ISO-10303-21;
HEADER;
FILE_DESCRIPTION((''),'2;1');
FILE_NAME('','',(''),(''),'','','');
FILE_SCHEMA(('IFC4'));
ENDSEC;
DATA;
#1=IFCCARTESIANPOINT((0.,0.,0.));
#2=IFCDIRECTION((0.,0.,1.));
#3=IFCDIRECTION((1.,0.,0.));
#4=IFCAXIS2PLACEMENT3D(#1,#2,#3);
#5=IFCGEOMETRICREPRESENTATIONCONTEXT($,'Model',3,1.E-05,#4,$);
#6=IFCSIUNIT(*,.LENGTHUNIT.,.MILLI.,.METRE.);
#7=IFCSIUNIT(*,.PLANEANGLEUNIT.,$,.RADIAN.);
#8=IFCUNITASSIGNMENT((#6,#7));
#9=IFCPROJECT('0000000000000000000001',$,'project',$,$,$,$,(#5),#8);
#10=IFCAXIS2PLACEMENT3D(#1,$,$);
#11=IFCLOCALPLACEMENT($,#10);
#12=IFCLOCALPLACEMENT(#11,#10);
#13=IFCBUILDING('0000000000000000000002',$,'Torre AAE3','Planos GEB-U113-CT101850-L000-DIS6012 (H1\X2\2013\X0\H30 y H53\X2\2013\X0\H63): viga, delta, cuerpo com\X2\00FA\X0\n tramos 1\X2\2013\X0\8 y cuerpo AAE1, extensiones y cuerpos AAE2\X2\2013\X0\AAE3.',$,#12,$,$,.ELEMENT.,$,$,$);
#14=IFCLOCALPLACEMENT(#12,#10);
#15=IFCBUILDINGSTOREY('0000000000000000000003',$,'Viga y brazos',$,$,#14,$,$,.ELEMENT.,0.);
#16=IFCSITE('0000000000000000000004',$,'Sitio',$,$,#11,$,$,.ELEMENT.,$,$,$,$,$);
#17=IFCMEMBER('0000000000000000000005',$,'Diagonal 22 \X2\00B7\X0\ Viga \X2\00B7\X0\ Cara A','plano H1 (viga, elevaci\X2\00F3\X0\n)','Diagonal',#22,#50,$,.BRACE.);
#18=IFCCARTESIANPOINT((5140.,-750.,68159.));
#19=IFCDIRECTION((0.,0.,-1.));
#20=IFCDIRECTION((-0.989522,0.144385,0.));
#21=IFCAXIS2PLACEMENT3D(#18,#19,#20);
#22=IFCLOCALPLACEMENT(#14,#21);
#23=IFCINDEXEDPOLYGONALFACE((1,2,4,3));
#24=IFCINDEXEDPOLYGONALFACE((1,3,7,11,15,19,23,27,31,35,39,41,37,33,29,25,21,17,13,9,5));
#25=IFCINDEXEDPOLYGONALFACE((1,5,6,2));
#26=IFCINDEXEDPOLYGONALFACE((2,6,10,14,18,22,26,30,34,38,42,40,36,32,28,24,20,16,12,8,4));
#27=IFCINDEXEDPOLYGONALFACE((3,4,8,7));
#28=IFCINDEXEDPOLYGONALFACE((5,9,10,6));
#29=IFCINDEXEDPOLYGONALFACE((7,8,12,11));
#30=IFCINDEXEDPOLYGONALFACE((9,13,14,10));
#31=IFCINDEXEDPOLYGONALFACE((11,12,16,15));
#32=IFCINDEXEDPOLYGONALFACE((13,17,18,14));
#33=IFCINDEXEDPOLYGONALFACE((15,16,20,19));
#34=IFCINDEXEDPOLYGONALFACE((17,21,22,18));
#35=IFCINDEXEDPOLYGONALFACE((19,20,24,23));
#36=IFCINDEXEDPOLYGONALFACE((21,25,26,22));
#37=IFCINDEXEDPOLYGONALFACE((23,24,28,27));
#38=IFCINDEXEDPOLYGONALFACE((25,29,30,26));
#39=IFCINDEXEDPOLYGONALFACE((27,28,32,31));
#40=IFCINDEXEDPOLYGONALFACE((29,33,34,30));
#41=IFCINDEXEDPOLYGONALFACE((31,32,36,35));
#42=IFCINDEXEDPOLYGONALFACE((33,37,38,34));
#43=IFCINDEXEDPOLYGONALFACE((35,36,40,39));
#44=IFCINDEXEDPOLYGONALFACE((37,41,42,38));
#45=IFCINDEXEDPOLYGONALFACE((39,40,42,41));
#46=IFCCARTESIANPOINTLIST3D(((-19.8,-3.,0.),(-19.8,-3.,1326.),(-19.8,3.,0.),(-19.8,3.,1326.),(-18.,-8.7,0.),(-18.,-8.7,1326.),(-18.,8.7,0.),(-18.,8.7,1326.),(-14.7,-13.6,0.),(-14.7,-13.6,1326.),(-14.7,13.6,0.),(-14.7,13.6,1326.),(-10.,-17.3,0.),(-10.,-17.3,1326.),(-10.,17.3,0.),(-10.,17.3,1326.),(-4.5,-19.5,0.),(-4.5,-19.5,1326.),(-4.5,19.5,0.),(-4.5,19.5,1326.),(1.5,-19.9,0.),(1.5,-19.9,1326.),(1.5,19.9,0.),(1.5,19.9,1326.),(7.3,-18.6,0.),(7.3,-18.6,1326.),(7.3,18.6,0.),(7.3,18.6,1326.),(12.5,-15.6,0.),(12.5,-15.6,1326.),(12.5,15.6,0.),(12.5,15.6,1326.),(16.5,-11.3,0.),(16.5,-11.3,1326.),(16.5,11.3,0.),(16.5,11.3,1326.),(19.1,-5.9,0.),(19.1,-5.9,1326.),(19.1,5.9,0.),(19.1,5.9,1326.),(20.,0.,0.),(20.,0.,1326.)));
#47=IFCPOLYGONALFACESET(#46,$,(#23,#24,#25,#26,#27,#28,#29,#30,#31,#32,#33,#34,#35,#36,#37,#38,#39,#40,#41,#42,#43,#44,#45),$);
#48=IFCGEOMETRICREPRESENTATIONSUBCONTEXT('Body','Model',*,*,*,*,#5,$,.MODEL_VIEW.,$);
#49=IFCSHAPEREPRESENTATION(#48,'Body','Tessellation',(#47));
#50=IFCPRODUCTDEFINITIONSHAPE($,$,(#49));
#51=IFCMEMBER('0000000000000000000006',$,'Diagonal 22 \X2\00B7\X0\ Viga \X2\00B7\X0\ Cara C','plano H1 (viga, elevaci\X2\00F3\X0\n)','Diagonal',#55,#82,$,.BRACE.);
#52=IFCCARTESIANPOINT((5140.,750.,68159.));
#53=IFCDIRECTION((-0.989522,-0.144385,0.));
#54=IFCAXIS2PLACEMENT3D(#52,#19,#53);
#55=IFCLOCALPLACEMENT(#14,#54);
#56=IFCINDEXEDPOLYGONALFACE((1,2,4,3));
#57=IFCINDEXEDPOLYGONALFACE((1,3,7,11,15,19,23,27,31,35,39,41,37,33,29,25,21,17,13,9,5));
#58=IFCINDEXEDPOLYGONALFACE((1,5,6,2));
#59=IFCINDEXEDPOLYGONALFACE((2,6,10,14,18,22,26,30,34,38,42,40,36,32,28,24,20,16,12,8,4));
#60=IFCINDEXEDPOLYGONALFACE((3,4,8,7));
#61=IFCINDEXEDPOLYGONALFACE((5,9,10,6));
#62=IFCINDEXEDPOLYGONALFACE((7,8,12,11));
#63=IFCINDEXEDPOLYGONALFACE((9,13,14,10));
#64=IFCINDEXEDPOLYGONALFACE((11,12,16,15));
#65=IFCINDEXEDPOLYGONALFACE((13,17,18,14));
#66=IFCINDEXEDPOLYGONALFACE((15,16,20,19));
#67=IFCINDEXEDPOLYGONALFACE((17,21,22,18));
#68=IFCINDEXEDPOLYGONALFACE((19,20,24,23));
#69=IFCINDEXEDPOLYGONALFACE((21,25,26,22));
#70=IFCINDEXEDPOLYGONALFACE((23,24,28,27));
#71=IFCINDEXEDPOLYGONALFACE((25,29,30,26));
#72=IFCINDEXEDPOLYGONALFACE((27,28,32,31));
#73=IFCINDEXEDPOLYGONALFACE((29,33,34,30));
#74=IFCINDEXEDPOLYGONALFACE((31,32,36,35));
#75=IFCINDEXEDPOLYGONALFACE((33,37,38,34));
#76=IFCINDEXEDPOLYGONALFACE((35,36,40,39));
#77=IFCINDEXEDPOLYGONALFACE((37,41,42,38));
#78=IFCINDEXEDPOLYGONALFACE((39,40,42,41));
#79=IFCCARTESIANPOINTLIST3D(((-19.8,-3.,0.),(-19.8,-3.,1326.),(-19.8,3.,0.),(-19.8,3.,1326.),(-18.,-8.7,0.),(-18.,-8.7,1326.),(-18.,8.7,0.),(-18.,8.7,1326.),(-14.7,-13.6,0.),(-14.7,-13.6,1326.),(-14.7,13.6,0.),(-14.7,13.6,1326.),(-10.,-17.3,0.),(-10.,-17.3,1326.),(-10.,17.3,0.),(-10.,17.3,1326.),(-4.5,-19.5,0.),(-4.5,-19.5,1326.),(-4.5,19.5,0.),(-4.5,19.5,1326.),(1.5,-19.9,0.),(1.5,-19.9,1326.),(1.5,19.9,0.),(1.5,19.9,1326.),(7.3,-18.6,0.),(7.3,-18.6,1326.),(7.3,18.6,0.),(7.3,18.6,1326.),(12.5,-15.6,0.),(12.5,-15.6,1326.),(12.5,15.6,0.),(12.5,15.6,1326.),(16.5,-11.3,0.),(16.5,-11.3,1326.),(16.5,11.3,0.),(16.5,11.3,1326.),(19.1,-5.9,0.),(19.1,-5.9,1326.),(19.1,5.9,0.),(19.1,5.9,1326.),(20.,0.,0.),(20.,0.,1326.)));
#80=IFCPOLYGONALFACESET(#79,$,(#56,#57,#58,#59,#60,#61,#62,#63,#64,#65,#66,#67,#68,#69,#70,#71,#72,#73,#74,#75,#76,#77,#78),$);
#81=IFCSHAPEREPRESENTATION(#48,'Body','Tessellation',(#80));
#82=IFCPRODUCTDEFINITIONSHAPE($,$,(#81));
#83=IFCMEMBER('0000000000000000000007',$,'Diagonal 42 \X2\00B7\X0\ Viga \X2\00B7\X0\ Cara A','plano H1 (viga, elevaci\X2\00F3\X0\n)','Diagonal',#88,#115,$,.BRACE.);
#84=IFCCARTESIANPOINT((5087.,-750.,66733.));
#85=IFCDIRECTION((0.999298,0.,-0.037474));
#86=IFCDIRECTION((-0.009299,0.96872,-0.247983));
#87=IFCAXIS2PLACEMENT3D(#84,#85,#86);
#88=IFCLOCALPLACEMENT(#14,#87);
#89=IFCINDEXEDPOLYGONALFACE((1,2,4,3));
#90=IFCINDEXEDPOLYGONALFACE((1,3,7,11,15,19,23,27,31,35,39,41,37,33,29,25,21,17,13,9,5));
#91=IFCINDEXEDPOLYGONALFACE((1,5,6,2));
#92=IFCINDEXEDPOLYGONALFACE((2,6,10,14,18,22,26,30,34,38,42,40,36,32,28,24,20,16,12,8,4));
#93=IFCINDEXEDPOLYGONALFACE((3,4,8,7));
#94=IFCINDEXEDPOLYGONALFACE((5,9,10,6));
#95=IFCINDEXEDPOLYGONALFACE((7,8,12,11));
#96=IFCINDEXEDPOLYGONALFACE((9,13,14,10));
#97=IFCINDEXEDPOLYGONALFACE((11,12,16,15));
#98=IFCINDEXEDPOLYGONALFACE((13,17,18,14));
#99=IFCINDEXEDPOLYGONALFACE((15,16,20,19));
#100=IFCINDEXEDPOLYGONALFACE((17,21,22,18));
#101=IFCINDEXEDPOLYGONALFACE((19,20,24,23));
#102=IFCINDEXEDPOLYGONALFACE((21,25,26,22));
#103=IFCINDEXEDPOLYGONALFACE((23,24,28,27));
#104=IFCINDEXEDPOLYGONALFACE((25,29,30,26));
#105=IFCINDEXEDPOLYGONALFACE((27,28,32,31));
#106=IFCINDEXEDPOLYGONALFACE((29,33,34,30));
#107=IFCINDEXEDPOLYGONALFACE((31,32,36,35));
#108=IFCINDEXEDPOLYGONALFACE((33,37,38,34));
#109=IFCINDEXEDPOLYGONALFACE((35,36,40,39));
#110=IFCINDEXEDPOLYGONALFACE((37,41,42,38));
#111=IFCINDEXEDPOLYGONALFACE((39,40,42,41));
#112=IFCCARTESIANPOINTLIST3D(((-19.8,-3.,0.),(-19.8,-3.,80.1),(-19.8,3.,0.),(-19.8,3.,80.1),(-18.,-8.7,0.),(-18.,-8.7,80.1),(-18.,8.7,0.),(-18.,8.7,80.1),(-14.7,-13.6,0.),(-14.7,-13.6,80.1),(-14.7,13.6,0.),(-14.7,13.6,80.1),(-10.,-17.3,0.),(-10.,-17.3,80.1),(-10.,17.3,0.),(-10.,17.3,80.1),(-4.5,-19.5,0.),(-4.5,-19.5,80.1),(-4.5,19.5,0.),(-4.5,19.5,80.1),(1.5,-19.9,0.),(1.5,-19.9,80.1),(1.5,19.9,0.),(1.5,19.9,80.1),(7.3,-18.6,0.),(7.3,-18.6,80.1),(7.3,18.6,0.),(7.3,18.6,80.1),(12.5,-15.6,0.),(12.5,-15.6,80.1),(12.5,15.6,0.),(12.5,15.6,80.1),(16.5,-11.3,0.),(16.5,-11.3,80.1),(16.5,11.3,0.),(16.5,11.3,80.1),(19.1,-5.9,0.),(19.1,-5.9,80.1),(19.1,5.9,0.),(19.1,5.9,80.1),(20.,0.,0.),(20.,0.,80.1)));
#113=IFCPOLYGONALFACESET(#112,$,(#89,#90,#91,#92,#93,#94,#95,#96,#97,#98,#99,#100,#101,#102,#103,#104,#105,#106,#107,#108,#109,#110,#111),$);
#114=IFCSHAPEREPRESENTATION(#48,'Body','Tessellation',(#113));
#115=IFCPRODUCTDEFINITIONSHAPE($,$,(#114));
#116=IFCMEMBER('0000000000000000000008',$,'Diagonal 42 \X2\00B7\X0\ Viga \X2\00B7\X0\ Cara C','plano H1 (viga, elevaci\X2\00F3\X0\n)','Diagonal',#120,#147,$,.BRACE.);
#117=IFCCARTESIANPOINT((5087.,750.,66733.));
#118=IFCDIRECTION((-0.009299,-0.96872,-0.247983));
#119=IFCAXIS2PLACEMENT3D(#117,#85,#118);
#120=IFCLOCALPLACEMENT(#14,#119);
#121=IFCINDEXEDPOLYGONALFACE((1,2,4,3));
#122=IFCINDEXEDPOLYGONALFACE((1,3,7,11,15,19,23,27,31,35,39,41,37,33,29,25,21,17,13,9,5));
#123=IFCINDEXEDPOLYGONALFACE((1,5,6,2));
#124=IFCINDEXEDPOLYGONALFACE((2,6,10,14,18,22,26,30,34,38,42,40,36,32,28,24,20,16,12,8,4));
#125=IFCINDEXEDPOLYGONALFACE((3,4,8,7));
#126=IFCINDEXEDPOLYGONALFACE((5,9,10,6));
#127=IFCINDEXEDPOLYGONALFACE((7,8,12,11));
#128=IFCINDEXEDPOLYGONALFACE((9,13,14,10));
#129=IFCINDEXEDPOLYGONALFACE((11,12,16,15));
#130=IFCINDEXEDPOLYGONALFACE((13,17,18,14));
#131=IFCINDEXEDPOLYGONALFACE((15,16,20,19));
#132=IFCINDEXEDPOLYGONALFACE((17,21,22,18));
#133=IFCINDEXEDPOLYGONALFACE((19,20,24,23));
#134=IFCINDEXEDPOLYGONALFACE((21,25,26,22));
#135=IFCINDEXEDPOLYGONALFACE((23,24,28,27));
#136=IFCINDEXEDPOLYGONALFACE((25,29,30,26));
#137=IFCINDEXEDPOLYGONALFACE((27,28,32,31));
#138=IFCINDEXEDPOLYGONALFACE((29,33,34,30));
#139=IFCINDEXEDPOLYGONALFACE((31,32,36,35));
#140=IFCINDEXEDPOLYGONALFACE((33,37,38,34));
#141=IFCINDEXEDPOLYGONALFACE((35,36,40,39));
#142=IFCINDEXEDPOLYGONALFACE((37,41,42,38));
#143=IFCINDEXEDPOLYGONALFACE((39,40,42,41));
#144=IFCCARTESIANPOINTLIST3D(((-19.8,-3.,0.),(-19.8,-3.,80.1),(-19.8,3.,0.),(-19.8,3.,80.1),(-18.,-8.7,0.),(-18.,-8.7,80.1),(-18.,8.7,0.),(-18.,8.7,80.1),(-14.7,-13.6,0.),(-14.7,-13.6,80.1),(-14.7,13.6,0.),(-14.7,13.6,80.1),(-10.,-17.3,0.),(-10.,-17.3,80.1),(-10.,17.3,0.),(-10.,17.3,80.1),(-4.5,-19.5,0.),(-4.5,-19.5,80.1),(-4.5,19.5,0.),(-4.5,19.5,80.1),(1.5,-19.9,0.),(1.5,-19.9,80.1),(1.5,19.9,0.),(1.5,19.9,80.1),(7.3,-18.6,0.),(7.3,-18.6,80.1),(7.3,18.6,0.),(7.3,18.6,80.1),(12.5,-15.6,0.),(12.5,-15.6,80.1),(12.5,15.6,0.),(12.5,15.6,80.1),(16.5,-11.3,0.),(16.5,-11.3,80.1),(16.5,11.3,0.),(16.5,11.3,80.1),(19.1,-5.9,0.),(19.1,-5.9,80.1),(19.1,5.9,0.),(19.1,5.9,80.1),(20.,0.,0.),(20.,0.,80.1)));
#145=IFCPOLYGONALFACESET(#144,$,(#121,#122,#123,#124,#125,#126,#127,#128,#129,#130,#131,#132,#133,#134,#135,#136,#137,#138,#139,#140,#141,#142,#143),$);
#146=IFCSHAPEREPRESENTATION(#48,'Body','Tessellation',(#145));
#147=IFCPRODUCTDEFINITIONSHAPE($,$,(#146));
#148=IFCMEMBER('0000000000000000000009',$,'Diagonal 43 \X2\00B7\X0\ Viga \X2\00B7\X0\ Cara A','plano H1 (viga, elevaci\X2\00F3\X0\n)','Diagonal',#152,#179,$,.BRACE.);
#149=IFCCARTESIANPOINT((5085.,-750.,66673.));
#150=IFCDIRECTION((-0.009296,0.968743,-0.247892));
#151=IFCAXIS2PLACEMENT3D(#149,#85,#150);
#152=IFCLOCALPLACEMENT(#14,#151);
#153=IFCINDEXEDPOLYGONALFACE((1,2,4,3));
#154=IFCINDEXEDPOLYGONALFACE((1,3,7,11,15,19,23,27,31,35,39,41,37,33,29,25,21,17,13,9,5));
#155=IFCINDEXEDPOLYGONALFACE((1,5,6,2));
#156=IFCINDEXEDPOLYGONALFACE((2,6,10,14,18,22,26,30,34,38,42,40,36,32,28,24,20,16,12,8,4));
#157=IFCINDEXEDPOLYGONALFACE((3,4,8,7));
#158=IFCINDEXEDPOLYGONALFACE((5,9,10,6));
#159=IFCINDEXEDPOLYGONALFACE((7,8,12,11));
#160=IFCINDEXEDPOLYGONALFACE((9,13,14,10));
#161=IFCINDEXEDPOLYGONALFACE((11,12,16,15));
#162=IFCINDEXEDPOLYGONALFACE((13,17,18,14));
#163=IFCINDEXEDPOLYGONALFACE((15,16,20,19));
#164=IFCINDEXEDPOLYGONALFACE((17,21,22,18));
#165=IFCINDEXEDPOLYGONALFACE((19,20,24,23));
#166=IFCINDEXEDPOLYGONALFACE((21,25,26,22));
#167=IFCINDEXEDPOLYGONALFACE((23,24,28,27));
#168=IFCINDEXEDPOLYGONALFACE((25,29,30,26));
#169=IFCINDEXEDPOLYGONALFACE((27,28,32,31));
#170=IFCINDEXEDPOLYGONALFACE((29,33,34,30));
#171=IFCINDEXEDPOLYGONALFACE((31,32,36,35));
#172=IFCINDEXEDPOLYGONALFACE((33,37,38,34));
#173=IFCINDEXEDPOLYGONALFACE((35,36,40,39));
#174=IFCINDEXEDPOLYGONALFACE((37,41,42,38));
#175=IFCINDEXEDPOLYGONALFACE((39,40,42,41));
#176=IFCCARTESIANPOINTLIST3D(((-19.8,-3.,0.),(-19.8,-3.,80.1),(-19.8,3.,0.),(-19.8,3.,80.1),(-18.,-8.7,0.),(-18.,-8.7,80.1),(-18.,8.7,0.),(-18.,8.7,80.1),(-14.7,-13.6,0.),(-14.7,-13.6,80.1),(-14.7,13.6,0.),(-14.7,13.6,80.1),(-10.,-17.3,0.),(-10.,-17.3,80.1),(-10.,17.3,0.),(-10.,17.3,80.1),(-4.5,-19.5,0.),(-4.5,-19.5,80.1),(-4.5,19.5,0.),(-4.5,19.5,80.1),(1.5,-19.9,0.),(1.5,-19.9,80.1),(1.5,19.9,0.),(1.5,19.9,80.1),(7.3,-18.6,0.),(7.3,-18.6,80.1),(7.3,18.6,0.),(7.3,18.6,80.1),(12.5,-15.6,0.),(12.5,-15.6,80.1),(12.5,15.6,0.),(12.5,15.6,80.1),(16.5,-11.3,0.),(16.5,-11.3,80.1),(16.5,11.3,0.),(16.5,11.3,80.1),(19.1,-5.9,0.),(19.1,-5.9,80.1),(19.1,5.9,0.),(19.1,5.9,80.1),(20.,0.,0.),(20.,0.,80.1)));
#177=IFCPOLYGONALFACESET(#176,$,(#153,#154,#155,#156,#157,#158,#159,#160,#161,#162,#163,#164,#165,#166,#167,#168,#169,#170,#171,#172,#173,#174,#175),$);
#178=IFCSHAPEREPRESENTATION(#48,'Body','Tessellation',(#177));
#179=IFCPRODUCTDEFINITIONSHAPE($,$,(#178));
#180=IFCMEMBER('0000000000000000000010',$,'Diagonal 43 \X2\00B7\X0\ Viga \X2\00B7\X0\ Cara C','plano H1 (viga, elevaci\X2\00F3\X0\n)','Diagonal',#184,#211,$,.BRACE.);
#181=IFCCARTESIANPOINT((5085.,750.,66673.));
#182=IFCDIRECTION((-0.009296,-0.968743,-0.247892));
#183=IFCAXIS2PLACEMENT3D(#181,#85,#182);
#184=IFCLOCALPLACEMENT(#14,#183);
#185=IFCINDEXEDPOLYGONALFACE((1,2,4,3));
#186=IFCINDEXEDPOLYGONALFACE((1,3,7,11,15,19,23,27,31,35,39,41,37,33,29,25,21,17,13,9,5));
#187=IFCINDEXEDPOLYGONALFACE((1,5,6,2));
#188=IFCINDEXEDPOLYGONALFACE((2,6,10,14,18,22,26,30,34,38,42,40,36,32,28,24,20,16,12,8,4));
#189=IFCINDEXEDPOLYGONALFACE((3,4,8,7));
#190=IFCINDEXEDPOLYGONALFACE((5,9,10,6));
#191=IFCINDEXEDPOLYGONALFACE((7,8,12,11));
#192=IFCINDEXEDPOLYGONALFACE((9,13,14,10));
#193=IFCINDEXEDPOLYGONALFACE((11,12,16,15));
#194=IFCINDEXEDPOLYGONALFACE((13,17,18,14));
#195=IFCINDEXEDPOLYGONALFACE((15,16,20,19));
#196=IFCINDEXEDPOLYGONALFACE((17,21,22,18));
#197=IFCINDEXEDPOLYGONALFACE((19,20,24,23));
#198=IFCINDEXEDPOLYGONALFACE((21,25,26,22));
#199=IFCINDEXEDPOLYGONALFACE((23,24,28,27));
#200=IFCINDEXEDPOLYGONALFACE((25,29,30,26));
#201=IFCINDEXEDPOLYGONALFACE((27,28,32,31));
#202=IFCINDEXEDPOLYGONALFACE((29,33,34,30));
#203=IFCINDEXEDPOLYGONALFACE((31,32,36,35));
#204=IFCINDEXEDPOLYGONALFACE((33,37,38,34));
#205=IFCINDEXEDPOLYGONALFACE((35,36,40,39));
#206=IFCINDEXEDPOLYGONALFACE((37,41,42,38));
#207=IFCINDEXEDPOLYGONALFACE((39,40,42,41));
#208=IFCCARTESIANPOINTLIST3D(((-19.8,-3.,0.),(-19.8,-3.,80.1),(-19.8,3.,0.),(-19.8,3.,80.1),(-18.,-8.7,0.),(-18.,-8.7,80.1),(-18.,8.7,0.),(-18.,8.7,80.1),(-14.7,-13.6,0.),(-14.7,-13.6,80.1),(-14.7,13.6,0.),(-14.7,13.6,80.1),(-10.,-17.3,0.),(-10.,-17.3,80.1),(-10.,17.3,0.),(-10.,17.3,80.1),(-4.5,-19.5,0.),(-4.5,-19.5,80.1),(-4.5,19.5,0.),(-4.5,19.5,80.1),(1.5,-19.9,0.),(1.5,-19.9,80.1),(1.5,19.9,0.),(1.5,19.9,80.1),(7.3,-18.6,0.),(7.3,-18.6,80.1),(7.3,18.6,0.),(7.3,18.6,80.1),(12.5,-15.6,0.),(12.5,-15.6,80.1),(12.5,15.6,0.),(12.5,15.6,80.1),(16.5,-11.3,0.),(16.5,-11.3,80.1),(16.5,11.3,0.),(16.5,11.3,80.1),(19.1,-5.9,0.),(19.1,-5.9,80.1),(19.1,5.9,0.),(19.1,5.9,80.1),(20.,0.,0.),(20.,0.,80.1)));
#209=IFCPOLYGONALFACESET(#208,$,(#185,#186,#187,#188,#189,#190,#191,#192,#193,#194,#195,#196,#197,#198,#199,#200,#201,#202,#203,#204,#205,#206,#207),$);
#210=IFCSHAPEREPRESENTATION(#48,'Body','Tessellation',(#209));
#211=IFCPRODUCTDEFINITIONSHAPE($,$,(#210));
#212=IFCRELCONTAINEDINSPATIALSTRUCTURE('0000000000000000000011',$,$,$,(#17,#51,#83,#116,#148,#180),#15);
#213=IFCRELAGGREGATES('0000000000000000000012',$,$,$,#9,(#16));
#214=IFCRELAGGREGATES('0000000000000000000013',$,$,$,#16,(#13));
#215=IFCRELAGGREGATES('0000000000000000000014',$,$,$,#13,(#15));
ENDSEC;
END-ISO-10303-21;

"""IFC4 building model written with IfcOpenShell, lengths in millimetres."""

from ifc_helpers import new_model, si_unit, frame, origin, origin_with_axes, place, context, subcontext, project, spatial, circle, extrude, element, save


model = new_model("IFC4")

# Units and contexts
model_context = context("Model", 3, precision=1e-05, world=origin_with_axes())
body_context = subcontext(model_context, "Body", "Model", "MODEL_VIEW")
ifc_project = project(units=[si_unit("LENGTHUNIT", "METRE", prefix="MILLI"), si_unit("PLANEANGLEUNIT", "RADIAN")], contexts=[model_context])

# Site, building, storey
site_placement = place(None, origin())
site = spatial("IfcSite", under=ifc_project, at=site_placement, Name="Sitio", CompositionType="ELEMENT")
building_placement = place(site_placement, origin())
building = spatial("IfcBuilding", under=site, at=building_placement, Name="Torre AAE3", Description="Planos GEB-U113-CT101850-L000-DIS6012 (H1–H30 y H53–H63): viga, delta, cuerpo común tramos 1–8 y cuerpo AAE1, extensiones y cuerpos AAE2–AAE3.", CompositionType="ELEMENT")
storey_placement = place(building_placement, origin())
storey = spatial("IfcBuildingStorey", under=building, at=storey_placement, Name="Viga y brazos", CompositionType="ELEMENT", Elevation=0.0)

# Members
for number, where, z_axis, x_axis, name in (
    (1, (5140.0, -750.0, 68159.0), (0.0, 0.0, -1.0), (-0.989522, 0.144385, 0.0), "Diagonal 22 · Viga · Cara A"),
    (2, (5140.0, 750.0, 68159.0), (0.0, 0.0, -1.0), (-0.989522, -0.144385, 0.0), "Diagonal 22 · Viga · Cara C"),
):
    element("IfcMember", number, at=place(storey_placement, frame(where, z_axis=z_axis, x_axis=x_axis)), inside=storey, Name=name, Description="plano H1 (viga, elevación)", ObjectType="Diagonal", PredefinedType="BRACE", context=body_context, shape_type="SweptSolid", body=[
        extrude(circle(Radius=20.0), None, (0.0, 0.0, 1.0), 1326.0),
    ])
for number, where, z_axis, x_axis, name in (
    (3, (5087.0, -750.0, 66733.0), (0.999298, 0.0, -0.037474), (-0.009299, 0.96872, -0.247983), "Diagonal 42 · Viga · Cara A"),
    (4, (5087.0, 750.0, 66733.0), (0.999298, 0.0, -0.037474), (-0.009299, -0.96872, -0.247983), "Diagonal 42 · Viga · Cara C"),
    (5, (5085.0, -750.0, 66673.0), (0.999298, 0.0, -0.037474), (-0.009296, 0.968743, -0.247892), "Diagonal 43 · Viga · Cara A"),
    (6, (5085.0, 750.0, 66673.0), (0.999298, 0.0, -0.037474), (-0.009296, -0.968743, -0.247892), "Diagonal 43 · Viga · Cara C"),
):
    element("IfcMember", number, at=place(storey_placement, frame(where, z_axis=z_axis, x_axis=x_axis)), inside=storey, Name=name, Description="plano H1 (viga, elevación)", ObjectType="Diagonal", PredefinedType="BRACE", context=body_context, shape_type="SweptSolid", body=[
        extrude(circle(Radius=20.0), None, (0.0, 0.0, 1.0), 80.1),
    ])

save(model, "model.ifc")
